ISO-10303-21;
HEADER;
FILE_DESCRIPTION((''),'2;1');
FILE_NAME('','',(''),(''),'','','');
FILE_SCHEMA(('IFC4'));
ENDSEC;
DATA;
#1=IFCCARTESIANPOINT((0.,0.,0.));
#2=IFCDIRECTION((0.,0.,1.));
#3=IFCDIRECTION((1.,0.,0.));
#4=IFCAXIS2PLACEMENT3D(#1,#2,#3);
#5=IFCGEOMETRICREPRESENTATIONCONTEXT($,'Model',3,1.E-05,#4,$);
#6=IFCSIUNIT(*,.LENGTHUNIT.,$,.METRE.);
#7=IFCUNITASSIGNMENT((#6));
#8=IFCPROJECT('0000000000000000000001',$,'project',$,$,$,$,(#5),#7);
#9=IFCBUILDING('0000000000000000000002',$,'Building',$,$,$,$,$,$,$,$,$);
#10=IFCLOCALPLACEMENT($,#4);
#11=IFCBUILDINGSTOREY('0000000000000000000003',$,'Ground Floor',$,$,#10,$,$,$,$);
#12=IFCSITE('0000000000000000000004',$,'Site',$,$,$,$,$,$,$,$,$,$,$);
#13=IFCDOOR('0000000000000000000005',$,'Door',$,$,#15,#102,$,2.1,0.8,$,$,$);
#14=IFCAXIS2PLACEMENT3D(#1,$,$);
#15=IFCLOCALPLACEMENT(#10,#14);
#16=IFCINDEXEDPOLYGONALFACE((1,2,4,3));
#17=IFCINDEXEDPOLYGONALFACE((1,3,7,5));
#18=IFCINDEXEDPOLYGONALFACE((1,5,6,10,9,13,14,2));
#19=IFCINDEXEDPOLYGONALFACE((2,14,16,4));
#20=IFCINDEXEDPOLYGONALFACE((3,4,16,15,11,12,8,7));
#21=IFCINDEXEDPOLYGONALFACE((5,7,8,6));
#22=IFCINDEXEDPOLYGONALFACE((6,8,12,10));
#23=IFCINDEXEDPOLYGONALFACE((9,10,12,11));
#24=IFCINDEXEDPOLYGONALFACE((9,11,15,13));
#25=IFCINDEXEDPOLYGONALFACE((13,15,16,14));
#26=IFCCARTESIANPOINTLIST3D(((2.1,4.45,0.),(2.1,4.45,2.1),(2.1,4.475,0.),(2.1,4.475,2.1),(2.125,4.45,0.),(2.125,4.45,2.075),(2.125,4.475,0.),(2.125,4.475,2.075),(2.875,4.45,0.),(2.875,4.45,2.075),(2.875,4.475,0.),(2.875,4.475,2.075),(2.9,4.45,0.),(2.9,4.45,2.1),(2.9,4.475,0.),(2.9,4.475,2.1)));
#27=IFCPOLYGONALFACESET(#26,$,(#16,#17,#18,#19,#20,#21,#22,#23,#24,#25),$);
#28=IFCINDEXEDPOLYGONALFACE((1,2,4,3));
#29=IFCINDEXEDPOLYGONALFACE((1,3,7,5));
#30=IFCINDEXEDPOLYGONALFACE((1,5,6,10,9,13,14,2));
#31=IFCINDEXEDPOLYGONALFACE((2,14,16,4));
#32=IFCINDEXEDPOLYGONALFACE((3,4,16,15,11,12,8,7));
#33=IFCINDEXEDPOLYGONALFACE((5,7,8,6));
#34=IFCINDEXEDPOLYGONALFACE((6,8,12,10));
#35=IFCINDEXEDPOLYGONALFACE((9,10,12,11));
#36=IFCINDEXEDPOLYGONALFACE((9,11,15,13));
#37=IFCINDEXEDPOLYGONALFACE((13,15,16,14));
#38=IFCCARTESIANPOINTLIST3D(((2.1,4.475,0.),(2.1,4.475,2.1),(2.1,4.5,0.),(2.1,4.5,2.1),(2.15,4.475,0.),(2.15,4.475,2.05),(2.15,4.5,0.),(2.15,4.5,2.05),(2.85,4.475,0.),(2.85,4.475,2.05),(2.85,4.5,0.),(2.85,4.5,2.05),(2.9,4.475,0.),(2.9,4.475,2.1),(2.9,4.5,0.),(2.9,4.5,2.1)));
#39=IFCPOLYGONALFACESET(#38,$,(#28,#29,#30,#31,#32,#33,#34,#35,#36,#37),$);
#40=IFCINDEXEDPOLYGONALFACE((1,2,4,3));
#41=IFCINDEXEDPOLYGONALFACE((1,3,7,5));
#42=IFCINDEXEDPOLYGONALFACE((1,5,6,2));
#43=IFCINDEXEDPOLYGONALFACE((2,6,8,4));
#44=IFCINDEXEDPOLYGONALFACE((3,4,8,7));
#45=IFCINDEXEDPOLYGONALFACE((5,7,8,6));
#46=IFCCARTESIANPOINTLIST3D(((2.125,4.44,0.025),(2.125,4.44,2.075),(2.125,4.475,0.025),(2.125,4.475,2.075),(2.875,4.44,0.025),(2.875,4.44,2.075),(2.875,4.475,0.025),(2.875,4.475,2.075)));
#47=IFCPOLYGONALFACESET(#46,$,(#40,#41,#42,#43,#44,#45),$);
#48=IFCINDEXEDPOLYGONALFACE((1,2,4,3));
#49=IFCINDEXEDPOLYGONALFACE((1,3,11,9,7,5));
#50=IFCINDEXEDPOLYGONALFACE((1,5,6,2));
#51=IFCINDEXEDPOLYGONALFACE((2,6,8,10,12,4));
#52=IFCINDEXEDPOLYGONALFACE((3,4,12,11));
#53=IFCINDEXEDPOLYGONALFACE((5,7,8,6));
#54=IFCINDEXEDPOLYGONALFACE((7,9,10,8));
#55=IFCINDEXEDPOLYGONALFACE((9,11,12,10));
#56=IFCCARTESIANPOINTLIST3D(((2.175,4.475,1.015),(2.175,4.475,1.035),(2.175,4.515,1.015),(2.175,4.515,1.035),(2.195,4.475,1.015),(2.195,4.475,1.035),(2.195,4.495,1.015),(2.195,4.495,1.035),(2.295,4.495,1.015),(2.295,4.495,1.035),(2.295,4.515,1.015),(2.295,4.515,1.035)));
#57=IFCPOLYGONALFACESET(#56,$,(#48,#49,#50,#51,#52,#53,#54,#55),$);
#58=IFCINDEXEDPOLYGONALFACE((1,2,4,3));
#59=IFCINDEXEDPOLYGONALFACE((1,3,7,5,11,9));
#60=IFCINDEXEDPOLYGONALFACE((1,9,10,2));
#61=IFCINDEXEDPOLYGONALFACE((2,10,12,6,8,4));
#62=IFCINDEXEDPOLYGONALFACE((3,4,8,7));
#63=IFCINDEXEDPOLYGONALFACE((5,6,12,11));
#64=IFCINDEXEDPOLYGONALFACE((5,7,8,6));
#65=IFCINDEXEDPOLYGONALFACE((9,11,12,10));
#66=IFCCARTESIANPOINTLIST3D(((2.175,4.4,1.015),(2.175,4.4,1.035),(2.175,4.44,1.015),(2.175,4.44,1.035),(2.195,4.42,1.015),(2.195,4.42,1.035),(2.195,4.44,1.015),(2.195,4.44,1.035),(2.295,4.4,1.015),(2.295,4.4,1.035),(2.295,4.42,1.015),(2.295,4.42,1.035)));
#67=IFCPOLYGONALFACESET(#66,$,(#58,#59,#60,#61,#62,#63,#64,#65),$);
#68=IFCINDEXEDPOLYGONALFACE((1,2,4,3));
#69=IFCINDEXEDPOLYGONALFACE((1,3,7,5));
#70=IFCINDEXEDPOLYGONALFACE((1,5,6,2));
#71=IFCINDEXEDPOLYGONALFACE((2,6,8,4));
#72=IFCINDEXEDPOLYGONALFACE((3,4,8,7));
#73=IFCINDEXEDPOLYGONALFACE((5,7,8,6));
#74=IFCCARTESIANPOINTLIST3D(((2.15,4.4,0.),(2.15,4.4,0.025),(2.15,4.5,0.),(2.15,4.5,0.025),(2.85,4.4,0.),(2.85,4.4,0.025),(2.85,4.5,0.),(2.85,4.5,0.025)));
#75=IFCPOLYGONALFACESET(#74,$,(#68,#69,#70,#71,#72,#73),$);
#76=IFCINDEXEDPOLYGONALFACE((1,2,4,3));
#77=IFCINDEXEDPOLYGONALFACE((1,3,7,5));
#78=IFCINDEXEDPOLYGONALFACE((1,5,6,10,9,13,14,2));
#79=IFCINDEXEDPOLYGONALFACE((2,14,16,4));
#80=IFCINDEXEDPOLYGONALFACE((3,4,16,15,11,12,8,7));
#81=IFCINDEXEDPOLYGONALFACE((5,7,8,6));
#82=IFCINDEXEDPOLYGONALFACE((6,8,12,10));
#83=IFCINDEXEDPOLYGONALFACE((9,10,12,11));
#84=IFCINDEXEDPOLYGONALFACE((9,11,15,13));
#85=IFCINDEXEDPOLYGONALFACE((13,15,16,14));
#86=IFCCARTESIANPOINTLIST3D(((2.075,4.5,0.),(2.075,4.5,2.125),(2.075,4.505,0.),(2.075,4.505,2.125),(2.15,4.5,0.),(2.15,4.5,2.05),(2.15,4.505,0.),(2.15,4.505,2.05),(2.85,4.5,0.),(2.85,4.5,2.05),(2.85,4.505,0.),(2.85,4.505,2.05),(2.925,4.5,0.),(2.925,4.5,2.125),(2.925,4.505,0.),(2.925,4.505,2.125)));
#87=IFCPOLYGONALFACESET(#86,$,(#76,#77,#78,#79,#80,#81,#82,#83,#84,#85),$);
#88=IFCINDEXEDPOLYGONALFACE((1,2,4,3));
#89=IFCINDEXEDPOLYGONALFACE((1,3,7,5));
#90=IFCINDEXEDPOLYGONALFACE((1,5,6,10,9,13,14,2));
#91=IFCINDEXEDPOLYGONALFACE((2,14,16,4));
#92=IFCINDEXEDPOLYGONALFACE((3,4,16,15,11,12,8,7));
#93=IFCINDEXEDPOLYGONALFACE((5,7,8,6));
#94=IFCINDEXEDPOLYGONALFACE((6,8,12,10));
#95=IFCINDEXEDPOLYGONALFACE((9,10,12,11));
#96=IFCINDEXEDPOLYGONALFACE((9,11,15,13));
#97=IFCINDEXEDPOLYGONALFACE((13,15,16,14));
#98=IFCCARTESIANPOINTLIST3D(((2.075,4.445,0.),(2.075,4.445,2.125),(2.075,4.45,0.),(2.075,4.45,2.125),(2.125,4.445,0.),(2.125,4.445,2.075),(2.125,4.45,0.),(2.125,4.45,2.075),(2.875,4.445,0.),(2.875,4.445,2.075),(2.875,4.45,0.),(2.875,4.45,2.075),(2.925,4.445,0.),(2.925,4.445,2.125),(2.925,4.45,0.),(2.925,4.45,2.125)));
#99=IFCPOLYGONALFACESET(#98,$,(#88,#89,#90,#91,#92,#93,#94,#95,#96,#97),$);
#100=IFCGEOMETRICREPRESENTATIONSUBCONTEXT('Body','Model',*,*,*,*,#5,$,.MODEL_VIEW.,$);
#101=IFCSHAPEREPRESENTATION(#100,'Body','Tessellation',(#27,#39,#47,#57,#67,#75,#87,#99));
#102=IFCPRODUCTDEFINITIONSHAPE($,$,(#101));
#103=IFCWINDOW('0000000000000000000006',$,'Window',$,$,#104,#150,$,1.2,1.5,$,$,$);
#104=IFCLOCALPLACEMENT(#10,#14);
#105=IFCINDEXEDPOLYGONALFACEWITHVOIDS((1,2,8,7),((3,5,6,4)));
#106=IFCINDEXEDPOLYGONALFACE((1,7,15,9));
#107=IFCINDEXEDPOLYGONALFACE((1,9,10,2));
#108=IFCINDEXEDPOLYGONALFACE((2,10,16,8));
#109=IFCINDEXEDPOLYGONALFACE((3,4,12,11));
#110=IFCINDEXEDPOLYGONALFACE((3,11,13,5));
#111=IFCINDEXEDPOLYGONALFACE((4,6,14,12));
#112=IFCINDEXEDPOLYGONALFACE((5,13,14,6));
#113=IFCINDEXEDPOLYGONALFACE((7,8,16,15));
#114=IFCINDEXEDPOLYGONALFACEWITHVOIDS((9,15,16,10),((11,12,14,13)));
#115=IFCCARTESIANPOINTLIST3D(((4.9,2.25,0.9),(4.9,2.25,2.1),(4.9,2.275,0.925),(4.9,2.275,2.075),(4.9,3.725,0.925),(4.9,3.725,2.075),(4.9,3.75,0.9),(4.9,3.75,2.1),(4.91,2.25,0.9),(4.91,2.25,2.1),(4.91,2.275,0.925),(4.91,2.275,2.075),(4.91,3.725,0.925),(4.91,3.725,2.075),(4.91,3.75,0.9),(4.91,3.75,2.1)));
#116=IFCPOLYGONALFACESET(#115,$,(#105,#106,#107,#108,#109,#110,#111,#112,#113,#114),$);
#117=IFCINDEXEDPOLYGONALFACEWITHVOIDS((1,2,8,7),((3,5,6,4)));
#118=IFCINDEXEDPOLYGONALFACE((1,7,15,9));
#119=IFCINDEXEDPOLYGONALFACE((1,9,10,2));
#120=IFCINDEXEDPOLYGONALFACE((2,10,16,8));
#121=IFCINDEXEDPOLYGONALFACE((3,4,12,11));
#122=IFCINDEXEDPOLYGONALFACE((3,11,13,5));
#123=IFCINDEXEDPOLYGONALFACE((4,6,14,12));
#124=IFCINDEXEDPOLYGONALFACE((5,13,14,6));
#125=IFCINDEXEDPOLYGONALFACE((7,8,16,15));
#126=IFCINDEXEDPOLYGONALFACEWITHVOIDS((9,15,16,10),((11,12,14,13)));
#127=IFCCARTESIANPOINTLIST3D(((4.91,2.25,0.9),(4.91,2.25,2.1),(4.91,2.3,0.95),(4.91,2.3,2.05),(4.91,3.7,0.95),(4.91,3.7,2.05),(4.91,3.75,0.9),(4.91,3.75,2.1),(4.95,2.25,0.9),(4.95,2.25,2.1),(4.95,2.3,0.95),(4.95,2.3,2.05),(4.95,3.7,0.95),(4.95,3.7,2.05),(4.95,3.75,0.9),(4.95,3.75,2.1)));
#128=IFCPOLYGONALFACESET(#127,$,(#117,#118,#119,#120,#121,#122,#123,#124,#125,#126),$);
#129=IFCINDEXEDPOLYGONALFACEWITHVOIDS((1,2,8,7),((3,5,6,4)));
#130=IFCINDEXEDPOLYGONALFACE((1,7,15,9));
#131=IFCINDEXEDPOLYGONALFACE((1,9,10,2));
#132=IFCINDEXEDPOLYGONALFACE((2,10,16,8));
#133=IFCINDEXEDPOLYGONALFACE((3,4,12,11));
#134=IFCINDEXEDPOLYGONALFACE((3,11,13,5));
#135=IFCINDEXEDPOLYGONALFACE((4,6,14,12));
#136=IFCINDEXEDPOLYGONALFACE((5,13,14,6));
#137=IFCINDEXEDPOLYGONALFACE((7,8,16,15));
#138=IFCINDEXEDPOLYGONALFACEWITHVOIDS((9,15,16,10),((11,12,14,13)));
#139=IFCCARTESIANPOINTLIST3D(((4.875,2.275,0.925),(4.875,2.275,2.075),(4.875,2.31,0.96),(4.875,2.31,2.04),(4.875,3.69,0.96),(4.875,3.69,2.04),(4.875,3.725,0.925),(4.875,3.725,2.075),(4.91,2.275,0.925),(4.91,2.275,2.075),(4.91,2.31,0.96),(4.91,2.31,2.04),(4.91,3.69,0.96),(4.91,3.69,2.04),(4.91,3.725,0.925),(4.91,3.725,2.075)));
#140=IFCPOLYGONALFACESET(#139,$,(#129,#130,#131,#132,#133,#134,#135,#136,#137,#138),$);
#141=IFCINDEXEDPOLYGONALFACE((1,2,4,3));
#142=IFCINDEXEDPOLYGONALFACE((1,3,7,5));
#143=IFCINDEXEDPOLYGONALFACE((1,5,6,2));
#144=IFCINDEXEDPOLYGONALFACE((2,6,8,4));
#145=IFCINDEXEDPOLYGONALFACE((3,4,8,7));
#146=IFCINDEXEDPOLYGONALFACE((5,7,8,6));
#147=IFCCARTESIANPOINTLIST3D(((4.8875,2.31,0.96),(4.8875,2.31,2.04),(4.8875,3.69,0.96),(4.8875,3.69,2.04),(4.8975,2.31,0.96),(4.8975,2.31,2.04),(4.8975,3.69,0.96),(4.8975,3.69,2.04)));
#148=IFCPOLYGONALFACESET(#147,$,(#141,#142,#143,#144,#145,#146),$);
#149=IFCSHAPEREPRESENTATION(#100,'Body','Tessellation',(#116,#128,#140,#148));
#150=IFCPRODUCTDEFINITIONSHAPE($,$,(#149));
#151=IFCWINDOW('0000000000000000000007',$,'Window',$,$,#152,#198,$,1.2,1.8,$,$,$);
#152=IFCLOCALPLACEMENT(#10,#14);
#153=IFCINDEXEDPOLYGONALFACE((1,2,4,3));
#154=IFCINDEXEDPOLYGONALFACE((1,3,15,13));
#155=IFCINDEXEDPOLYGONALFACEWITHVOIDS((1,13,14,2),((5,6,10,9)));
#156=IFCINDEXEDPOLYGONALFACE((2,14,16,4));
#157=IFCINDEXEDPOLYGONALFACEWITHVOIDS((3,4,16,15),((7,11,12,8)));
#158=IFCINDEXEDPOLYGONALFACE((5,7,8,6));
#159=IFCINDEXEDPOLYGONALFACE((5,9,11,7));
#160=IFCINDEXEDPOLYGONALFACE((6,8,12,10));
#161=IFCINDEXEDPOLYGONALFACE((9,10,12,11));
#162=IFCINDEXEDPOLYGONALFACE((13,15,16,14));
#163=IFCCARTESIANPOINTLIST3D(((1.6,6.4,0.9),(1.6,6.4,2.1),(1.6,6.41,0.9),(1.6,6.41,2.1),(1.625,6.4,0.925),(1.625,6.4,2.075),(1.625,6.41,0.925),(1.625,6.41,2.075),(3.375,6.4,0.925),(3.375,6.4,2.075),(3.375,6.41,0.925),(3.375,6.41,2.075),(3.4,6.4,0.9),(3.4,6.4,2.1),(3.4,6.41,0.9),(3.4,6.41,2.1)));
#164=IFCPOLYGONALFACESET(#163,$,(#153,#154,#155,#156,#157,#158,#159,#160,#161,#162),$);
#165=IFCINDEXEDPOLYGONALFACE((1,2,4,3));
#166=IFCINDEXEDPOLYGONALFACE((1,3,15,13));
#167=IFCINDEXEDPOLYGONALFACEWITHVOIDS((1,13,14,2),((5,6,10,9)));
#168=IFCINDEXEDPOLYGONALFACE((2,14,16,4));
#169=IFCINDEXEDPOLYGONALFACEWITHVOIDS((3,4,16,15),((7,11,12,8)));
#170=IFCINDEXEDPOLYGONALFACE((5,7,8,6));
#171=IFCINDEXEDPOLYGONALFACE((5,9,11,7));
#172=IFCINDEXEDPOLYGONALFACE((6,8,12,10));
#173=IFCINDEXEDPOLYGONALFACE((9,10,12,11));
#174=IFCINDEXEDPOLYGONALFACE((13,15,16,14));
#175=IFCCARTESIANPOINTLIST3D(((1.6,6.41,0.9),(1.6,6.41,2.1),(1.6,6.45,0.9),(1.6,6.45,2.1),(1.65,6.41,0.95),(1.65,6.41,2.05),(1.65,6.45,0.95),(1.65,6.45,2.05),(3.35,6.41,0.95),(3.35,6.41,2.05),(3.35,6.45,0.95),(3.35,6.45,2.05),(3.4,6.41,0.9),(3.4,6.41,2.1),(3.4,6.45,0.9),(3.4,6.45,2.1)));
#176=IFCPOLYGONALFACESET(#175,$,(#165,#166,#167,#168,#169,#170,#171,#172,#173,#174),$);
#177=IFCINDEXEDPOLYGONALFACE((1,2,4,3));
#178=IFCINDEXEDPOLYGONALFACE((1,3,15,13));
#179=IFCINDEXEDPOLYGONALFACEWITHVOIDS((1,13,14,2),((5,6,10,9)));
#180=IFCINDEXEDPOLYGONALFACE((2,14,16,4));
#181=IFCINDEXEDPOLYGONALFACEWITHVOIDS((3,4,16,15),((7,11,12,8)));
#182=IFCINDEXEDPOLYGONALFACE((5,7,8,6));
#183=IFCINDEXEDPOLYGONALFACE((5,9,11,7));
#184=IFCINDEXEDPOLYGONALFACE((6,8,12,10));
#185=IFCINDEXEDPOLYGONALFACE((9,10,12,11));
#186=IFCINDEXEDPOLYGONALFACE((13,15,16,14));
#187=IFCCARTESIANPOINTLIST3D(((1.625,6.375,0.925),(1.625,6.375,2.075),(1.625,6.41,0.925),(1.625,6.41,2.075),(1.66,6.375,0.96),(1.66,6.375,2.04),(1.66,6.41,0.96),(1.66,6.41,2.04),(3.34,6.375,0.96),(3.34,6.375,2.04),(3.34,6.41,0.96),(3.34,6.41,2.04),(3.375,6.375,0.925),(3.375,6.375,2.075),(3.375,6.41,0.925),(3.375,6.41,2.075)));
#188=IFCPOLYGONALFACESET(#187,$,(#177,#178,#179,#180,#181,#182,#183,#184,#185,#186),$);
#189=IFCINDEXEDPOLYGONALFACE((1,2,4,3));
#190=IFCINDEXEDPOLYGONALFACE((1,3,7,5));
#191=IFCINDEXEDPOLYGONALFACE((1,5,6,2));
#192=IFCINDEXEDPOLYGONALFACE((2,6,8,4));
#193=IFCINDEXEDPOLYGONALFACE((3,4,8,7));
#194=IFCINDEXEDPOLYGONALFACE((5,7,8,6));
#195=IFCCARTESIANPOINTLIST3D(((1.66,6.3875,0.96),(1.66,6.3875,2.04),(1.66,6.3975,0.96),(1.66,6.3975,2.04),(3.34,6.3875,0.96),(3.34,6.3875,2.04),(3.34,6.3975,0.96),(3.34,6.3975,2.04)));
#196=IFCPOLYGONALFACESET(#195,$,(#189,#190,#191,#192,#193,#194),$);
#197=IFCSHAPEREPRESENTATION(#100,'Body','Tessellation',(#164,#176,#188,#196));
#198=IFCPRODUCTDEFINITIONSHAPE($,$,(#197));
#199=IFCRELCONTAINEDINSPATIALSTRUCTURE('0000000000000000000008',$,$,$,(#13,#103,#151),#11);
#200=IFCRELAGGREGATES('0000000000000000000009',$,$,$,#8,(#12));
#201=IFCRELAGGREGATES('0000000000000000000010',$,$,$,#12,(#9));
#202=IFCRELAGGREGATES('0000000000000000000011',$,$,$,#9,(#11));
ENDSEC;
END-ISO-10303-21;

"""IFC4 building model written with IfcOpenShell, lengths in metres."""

from ifc_helpers import new_model, si_unit, frame, origin_with_axes, place, context, subcontext, project, spatial, line, indexed_curve, outline, extrude, element, save


model = new_model("IFC4")

# Units and contexts
model_context = context("Model", 3, precision=1e-05, world=origin_with_axes())
body_context = subcontext(model_context, "Body", "Model", "MODEL_VIEW")
ifc_project = project(units=[si_unit("LENGTHUNIT", "METRE")], contexts=[model_context])

# Site, building, storey
site = spatial("IfcSite", under=ifc_project, Name="Site")
building = spatial("IfcBuilding", under=site, Name="Building")
storey_placement = place(None, origin_with_axes())
storey = spatial("IfcBuildingStorey", under=building, at=storey_placement, Name="Ground Floor")

# Door
door_1_placement = place(storey_placement, frame((2.9, 4.5, 0.0), z_axis=(0.0, 0.0, 1.0), x_axis=(-1.0, 0.0, 0.0)))
element("IfcDoor", 1, at=door_1_placement, inside=storey, Name="Door", OverallHeight=2.1, OverallWidth=0.8, context=body_context, shape_type="SweptSolid", body=[
    extrude(outline(indexed_curve([(0.0, 0.0), (0.0, 2.1), (0.8, 2.1), (0.8, 0.0), (0.775, 0.0), (0.775, 2.075), (0.025, 2.075), (0.025, 0.0)], segments=[line(1, 2, 3, 4, 5, 6, 7, 8, 1)])), frame((0.0, 0.025, 0.0), z_axis=(0.0, -1.0, 0.0), x_axis=(1.0, 0.0, 0.0)), (0.0, 0.0, -1.0), 0.025),
    extrude(outline(indexed_curve([(0.0, 0.0), (0.0, 2.1), (0.8, 2.1), (0.8, 0.0), (0.75, 0.0), (0.75, 2.05), (0.05, 2.05), (0.05, 0.0)], segments=[line(1, 2, 3, 4, 5, 6, 7, 8, 1)])), frame((0.0, 0.0, 0.0), z_axis=(0.0, -1.0, 0.0), x_axis=(1.0, 0.0, 0.0)), (0.0, 0.0, -1.0), 0.025),
    extrude(outline(indexed_curve([(0.0, 0.0), (0.75, 0.0), (0.75, 0.035), (0.0, 0.035)], segments=[line(1, 2, 3, 4, 1)])), frame((0.025, 0.025, 0.025), z_axis=(0.0, 0.0, 1.0), x_axis=(1.0, 0.0, 0.0)), (0.0, 0.0, 1.0), 2.05),
    extrude(outline(indexed_curve([(0.0, 0.0), (0.0, -0.04), (-0.12, -0.04), (-0.12, -0.02), (-0.02, -0.02), (-0.02, 0.0)], segments=[line(1, 2, 3, 4, 5, 6, 1)])), frame((0.725, 0.025, 1.015), z_axis=(0.0, 0.0, 1.0), x_axis=(1.0, 0.0, 0.0)), (0.0, 0.0, 1.0), 0.02),
    extrude(outline(indexed_curve([(0.0, 0.0), (0.0, 0.04), (-0.12, 0.04), (-0.12, 0.02), (-0.02, 0.02), (-0.02, 0.0)], segments=[line(1, 2, 3, 4, 5, 6, 1)])), frame((0.725, 0.06, 1.015), z_axis=(0.0, 0.0, 1.0), x_axis=(1.0, 0.0, 0.0)), (0.0, 0.0, 1.0), 0.02),
    extrude(outline(indexed_curve([(0.0, 0.0), (0.7, 0.0), (0.7, 0.1), (0.0, 0.1)], segments=[line(1, 2, 3, 4, 1)])), frame((0.05, 0.0, 0.0), z_axis=(0.0, 0.0, 1.0), x_axis=(1.0, 0.0, 0.0)), (0.0, 0.0, 1.0), 0.025),
    extrude(outline(indexed_curve([(0.0, 0.0), (0.0, 2.125), (0.85, 2.125), (0.85, 0.0), (0.775, 0.0), (0.775, 2.05), (0.075, 2.05), (0.075, 0.0)], segments=[line(1, 2, 3, 4, 5, 6, 7, 8, 1)])), frame((-0.025, -0.005, 0.0), z_axis=(0.0, -1.0, 0.0), x_axis=(1.0, 0.0, 0.0)), (0.0, 0.0, -1.0), 0.005),
    extrude(outline(indexed_curve([(0.0, 0.0), (0.0, 2.125), (0.85, 2.125), (0.85, 0.0), (0.8, 0.0), (0.8, 2.075), (0.05, 2.075), (0.05, 0.0)], segments=[line(1, 2, 3, 4, 5, 6, 7, 8, 1)])), frame((-0.025, 0.05, 0.0), z_axis=(0.0, -1.0, 0.0), x_axis=(1.0, 0.0, 0.0)), (0.0, 0.0, -1.0), 0.005),
])

# Windows
window_1_placement = place(storey_placement, frame((5.0, 2.25, 0.9), z_axis=(0.0, 0.0, 1.0), x_axis=(0.0, 1.0, 0.0)))
element("IfcWindow", 2, at=window_1_placement, inside=storey, Name="Window", OverallHeight=1.2, OverallWidth=1.5, context=body_context, shape_type="SweptSolid", body=[
    extrude(outline(indexed_curve([(0.0, 0.0), (1.5, 0.0), (1.5, 1.2), (0.0, 1.2)], segments=[line(1, 2, 3, 4, 1)]), holes=[indexed_curve([(0.025, 0.025), (1.475, 0.025), (1.475, 1.175), (0.025, 1.175)], segments=[line(1, 2, 3, 4, 1)])]), frame((0.0, 0.09, 0.0), z_axis=(0.0, -1.0, 0.0), x_axis=(1.0, 0.0, 0.0)), (0.0, 0.0, -1.0), 0.01),
    extrude(outline(indexed_curve([(0.0, 0.0), (1.5, 0.0), (1.5, 1.2), (0.0, 1.2)], segments=[line(1, 2, 3, 4, 1)]), holes=[indexed_curve([(0.05, 0.05), (1.45, 0.05), (1.45, 1.15), (0.05, 1.15)], segments=[line(1, 2, 3, 4, 1)])]), frame((0.0, 0.05, 0.0), z_axis=(0.0, -1.0, 0.0), x_axis=(1.0, 0.0, 0.0)), (0.0, 0.0, -1.0), 0.04),
    extrude(outline(indexed_curve([(0.0, 0.0), (1.45, 0.0), (1.45, 1.15), (0.0, 1.15)], segments=[line(1, 2, 3, 4, 1)]), holes=[indexed_curve([(0.035, 0.035), (1.415, 0.035), (1.415, 1.115), (0.035, 1.115)], segments=[line(1, 2, 3, 4, 1)])]), frame((0.025, 0.09, 0.025), z_axis=(0.0, -1.0, 0.0), x_axis=(1.0, 0.0, 0.0)), (0.0, 0.0, -1.0), 0.035),
    extrude(outline(indexed_curve([(0.035, 0.035), (1.415, 0.035), (1.415, 1.115), (0.035, 1.115)], segments=[line(1, 2, 3, 4, 1)])), frame((0.025, 0.1025, 0.025), z_axis=(0.0, -1.0, 0.0), x_axis=(1.0, 0.0, 0.0)), (0.0, 0.0, -1.0), 0.01),
])
window_2_placement = place(storey_placement, frame((3.4, 6.5, 0.9), z_axis=(0.0, 0.0, 1.0), x_axis=(-1.0, 0.0, 0.0)))
element("IfcWindow", 3, at=window_2_placement, inside=storey, Name="Window", OverallHeight=1.2, OverallWidth=1.8, context=body_context, shape_type="SweptSolid", body=[
    extrude(outline(indexed_curve([(0.0, 0.0), (1.8, 0.0), (1.8, 1.2), (0.0, 1.2)], segments=[line(1, 2, 3, 4, 1)]), holes=[indexed_curve([(0.025, 0.025), (1.775, 0.025), (1.775, 1.175), (0.025, 1.175)], segments=[line(1, 2, 3, 4, 1)])]), frame((0.0, 0.09, 0.0), z_axis=(0.0, -1.0, 0.0), x_axis=(1.0, 0.0, 0.0)), (0.0, 0.0, -1.0), 0.01),
    extrude(outline(indexed_curve([(0.0, 0.0), (1.8, 0.0), (1.8, 1.2), (0.0, 1.2)], segments=[line(1, 2, 3, 4, 1)]), holes=[indexed_curve([(0.05, 0.05), (1.75, 0.05), (1.75, 1.15), (0.05, 1.15)], segments=[line(1, 2, 3, 4, 1)])]), frame((0.0, 0.05, 0.0), z_axis=(0.0, -1.0, 0.0), x_axis=(1.0, 0.0, 0.0)), (0.0, 0.0, -1.0), 0.04),
    extrude(outline(indexed_curve([(0.0, 0.0), (1.75, 0.0), (1.75, 1.15), (0.0, 1.15)], segments=[line(1, 2, 3, 4, 1)]), holes=[indexed_curve([(0.035, 0.035), (1.715, 0.035), (1.715, 1.115), (0.035, 1.115)], segments=[line(1, 2, 3, 4, 1)])]), frame((0.025, 0.09, 0.025), z_axis=(0.0, -1.0, 0.0), x_axis=(1.0, 0.0, 0.0)), (0.0, 0.0, -1.0), 0.035),
    extrude(outline(indexed_curve([(0.035, 0.035), (1.715, 0.035), (1.715, 1.115), (0.035, 1.115)], segments=[line(1, 2, 3, 4, 1)])), frame((0.025, 0.1025, 0.025), z_axis=(0.0, -1.0, 0.0), x_axis=(1.0, 0.0, 0.0)), (0.0, 0.0, -1.0), 0.01),
])

save(model, "model.ifc")
